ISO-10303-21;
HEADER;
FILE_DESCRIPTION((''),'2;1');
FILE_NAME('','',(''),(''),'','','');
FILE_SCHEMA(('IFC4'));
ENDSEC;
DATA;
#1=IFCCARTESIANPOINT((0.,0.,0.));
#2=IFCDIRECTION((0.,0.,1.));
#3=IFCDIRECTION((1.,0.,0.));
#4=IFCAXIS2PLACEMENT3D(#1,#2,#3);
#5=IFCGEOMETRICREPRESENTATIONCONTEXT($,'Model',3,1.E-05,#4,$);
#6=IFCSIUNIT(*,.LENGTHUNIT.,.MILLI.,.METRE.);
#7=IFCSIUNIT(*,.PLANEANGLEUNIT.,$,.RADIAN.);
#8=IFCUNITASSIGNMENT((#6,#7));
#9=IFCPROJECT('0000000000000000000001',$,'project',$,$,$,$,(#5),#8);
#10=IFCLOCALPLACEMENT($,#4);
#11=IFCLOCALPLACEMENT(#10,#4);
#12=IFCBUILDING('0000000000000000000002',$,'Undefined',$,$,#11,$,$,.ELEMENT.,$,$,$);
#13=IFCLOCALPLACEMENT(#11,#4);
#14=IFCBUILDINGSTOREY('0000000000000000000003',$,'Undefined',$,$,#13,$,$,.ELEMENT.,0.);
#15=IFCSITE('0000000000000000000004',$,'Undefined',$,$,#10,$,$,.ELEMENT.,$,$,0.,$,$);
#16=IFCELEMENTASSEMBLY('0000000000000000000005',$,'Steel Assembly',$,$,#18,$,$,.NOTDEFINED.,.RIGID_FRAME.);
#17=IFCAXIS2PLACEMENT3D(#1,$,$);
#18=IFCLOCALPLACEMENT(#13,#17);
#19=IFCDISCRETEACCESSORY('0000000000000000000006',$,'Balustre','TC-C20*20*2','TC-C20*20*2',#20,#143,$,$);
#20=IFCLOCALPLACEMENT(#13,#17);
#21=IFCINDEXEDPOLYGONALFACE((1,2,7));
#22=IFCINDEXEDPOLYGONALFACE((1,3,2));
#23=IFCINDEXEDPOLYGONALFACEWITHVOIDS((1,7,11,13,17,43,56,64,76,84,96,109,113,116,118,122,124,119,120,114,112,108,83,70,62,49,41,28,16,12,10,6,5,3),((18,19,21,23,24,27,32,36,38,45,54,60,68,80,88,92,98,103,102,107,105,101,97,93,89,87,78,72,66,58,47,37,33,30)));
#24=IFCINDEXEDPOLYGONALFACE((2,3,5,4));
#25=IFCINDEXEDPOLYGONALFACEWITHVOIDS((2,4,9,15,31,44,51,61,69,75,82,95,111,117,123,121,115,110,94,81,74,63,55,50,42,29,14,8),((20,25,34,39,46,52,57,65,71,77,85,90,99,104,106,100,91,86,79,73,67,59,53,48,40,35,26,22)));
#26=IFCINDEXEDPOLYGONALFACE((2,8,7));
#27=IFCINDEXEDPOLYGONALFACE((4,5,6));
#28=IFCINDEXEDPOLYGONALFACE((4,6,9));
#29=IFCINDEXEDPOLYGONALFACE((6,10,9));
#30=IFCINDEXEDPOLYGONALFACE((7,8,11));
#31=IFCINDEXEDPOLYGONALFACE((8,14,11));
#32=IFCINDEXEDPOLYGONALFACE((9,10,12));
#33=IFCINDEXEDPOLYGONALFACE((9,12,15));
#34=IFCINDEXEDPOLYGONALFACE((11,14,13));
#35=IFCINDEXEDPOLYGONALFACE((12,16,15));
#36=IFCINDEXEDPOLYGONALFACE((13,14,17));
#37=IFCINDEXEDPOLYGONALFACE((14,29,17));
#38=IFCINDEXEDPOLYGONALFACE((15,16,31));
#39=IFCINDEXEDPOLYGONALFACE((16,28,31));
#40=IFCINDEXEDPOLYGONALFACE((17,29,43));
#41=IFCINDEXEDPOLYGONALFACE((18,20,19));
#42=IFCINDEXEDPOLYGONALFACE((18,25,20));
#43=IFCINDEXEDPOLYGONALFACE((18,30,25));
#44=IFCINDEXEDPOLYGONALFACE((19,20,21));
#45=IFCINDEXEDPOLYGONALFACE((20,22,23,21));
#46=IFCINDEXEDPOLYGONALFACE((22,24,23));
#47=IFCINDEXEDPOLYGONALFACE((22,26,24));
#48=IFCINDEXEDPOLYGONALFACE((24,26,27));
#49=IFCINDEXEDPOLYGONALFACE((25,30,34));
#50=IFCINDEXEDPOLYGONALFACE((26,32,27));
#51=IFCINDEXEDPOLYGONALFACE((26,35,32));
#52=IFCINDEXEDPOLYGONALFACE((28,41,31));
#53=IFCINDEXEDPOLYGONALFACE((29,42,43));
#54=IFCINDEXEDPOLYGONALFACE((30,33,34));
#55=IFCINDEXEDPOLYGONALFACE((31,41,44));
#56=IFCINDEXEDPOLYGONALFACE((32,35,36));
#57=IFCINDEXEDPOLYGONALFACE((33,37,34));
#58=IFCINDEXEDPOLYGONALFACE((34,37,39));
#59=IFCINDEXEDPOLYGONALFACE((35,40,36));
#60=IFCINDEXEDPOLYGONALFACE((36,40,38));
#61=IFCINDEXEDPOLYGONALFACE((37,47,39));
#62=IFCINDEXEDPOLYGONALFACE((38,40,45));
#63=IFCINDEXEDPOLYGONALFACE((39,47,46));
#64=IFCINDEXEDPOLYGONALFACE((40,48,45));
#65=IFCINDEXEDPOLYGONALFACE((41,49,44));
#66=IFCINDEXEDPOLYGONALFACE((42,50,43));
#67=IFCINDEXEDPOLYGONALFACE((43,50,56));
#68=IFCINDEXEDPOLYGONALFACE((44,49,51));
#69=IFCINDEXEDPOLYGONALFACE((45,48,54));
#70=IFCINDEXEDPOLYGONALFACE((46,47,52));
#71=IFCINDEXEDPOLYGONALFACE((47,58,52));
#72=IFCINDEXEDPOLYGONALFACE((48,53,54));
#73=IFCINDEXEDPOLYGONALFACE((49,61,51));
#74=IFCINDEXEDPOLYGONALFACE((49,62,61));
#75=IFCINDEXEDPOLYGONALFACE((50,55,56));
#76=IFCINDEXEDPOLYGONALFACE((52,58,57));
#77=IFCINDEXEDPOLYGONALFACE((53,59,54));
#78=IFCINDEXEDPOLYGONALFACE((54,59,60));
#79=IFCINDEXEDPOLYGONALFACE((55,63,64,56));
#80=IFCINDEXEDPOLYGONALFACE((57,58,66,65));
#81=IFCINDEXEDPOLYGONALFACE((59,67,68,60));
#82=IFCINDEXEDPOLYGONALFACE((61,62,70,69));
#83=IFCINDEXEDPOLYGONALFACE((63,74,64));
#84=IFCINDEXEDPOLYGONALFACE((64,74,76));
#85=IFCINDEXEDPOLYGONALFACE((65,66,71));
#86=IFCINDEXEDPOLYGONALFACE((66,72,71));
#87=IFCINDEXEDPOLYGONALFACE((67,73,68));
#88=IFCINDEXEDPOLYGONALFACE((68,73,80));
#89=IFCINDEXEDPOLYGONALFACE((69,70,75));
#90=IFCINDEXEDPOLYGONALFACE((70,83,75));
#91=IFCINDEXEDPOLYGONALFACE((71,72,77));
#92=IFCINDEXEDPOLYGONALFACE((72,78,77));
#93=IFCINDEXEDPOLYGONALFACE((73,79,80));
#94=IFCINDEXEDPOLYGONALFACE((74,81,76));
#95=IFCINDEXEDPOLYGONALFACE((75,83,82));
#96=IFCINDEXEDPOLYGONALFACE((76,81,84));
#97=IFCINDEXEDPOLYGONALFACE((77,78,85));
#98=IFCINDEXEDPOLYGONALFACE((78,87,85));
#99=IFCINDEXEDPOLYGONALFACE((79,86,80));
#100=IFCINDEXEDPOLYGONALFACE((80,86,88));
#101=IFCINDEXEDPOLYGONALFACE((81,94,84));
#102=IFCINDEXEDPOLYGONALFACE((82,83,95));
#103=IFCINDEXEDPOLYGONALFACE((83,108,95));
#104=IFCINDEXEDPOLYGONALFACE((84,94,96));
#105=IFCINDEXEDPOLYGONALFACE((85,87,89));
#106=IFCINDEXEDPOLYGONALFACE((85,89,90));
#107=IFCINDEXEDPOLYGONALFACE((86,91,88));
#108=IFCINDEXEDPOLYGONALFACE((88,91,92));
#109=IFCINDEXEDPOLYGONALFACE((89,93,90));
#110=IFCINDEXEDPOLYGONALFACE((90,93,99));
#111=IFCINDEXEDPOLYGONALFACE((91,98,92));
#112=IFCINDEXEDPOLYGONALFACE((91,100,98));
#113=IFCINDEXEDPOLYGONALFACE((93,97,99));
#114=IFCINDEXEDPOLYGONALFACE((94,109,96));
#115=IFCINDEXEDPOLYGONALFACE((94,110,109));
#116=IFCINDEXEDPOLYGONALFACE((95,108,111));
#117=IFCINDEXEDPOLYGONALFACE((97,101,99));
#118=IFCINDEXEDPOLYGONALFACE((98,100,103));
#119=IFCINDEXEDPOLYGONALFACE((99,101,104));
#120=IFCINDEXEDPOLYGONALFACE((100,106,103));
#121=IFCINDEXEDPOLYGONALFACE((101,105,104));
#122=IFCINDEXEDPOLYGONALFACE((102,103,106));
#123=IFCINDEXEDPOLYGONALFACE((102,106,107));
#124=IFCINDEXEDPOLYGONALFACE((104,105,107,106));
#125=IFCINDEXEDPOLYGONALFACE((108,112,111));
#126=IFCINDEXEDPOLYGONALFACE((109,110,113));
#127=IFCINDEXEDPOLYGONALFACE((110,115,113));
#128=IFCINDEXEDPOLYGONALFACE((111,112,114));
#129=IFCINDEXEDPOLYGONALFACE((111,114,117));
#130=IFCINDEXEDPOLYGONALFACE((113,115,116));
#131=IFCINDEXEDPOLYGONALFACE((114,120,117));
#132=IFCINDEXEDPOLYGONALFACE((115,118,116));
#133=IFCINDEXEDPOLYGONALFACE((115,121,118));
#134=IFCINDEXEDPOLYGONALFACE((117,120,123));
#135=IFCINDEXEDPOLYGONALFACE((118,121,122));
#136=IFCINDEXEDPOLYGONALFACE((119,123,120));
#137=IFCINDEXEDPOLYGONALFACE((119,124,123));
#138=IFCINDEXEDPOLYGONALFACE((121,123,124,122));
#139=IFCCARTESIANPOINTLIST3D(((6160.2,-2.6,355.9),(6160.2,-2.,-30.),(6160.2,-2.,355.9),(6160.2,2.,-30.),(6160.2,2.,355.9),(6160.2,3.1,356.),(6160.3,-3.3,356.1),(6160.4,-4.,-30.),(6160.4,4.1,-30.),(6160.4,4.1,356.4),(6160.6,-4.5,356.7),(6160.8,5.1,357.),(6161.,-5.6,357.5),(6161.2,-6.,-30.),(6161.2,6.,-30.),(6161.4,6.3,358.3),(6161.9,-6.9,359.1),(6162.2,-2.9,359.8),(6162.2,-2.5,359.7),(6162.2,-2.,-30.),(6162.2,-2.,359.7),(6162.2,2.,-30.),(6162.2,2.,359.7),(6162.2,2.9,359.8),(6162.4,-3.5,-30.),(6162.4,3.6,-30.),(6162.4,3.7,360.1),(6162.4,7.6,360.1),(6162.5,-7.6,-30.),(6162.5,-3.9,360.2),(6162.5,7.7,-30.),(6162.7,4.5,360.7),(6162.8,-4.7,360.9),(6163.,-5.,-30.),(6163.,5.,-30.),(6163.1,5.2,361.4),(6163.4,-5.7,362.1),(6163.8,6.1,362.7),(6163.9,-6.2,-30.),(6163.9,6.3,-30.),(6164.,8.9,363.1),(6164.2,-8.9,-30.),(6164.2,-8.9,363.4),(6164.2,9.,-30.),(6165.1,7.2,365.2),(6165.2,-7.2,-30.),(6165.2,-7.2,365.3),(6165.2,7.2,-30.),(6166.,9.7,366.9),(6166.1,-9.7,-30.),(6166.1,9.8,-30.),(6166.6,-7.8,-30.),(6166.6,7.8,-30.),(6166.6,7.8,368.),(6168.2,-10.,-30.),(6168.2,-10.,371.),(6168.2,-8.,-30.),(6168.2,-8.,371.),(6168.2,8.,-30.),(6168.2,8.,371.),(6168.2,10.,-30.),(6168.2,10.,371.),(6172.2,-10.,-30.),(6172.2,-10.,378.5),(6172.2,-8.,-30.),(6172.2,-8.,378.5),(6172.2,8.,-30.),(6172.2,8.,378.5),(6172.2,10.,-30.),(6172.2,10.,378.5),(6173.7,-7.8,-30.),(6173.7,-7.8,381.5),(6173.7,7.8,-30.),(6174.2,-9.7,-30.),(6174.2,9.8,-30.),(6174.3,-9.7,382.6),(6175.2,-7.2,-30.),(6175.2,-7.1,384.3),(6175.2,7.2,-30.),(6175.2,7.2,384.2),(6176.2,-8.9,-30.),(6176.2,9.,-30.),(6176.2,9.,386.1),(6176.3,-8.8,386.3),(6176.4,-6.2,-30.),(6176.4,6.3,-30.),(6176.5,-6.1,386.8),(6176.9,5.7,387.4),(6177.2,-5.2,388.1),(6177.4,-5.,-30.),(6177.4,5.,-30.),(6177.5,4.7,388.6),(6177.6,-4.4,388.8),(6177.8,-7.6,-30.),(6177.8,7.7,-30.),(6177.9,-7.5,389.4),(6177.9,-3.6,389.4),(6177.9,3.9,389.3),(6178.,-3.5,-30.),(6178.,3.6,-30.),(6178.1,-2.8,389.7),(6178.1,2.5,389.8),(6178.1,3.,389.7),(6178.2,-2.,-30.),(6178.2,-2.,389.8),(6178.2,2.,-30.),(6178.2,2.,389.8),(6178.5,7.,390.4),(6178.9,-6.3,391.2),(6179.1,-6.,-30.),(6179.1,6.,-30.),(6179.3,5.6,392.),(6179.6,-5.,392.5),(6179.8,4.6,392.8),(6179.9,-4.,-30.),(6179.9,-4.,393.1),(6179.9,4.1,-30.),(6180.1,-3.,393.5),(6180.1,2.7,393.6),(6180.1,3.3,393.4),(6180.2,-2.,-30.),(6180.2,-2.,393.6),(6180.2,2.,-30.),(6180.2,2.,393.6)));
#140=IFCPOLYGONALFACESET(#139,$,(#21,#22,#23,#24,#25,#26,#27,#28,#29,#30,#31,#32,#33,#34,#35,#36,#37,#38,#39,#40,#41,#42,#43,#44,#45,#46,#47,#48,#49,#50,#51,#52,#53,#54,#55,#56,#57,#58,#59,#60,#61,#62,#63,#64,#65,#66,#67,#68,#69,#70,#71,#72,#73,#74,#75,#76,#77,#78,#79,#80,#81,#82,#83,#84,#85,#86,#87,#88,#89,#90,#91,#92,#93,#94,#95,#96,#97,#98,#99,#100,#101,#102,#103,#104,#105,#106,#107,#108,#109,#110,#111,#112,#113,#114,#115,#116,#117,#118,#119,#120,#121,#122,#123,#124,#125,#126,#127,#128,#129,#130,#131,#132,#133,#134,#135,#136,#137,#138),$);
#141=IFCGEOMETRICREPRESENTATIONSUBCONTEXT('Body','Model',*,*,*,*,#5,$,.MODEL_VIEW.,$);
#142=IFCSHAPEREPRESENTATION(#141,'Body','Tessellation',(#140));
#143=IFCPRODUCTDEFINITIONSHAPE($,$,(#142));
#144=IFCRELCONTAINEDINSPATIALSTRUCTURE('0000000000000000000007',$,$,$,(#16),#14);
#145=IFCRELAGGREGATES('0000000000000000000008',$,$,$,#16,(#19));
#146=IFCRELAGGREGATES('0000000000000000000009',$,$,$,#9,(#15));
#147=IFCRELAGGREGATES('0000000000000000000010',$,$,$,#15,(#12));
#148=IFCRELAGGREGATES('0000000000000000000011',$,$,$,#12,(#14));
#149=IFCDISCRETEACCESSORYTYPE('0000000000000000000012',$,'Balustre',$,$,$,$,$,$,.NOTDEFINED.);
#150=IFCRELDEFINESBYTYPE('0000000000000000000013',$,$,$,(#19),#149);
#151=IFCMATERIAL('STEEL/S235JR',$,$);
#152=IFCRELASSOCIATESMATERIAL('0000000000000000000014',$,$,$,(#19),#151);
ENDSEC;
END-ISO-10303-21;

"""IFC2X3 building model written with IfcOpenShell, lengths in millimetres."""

from ifc_helpers import new_model, si_unit, frame, origin_with_axes, origin_2d_with_axis, place, context, subcontext, project, spatial, hollow_rectangle, extrude, clip, halfspace, material, type_object, element, aggregate, save


model = new_model("IFC2X3")

# Units and contexts
model_context = context("Model", 3, precision=1e-05, world=origin_with_axes())
body_context = subcontext(model_context, "Body", "Model", "MODEL_VIEW")
ifc_project = project(units=[si_unit("LENGTHUNIT", "METRE", prefix="MILLI"), si_unit("PLANEANGLEUNIT", "RADIAN")], contexts=[model_context])

# Site, building, storey
site_placement = place(None, origin_with_axes())
site = spatial("IfcSite", under=ifc_project, at=site_placement, Name="Undefined", CompositionType="ELEMENT", RefElevation=0.0)
building_placement = place(site_placement, origin_with_axes())
building = spatial("IfcBuilding", under=site, at=building_placement, Name="Undefined", CompositionType="ELEMENT")
storey_placement = place(building_placement, origin_with_axes())
storey = spatial("IfcBuildingStorey", under=building, at=storey_placement, Name="Undefined", CompositionType="ELEMENT", Elevation=0.0)

# Element assembly
assembly_1_placement = place(storey_placement, origin_with_axes())
assembly_1 = element("IfcElementAssembly", 1, at=assembly_1_placement, inside=storey, Name="Steel Assembly", AssemblyPlace="NOTDEFINED", PredefinedType="RIGID_FRAME")
ifc_material = material(Name="STEEL/S235JR")

# Discrete accessory
discrete_accessory_type_1 = type_object("IfcDiscreteAccessoryType", Name="Balustre")
discrete_accessory_1_placement = place(assembly_1_placement, frame((6170.2, 0.0, -30.0), z_axis=(0.0, 0.0, 1.0), x_axis=(1.0, 0.0, 0.0)))
discrete_accessory_1 = element("IfcDiscreteAccessory", 2, at=discrete_accessory_1_placement, type_object=discrete_accessory_type_1, material=ifc_material, Name="Balustre", Description="TC-C20*20*2", ObjectType="TC-C20*20*2", context=body_context, shape_type="Clipping", body=[
    clip(extrude(hollow_rectangle(XDim=20.0, YDim=20.0, WallThickness=2.0, InnerFilletRadius=6.0, OuterFilletRadius=8.0, at=origin_2d_with_axis()), frame((0.0, 0.0, 423.8), z_axis=(0.0, 0.0, -1.0), x_axis=(-1.0, 0.0, 0.0)), (0.0, 0.0, 1.0), 423.8), halfspace(frame((13.3, 0.0, 429.9), z_axis=(0.883506, 0.000005, -0.46842), x_axis=(-0.000005, 1.0, 0.0)), True)),
])
aggregate(assembly_1, [discrete_accessory_1])

save(model, "model.ifc")
